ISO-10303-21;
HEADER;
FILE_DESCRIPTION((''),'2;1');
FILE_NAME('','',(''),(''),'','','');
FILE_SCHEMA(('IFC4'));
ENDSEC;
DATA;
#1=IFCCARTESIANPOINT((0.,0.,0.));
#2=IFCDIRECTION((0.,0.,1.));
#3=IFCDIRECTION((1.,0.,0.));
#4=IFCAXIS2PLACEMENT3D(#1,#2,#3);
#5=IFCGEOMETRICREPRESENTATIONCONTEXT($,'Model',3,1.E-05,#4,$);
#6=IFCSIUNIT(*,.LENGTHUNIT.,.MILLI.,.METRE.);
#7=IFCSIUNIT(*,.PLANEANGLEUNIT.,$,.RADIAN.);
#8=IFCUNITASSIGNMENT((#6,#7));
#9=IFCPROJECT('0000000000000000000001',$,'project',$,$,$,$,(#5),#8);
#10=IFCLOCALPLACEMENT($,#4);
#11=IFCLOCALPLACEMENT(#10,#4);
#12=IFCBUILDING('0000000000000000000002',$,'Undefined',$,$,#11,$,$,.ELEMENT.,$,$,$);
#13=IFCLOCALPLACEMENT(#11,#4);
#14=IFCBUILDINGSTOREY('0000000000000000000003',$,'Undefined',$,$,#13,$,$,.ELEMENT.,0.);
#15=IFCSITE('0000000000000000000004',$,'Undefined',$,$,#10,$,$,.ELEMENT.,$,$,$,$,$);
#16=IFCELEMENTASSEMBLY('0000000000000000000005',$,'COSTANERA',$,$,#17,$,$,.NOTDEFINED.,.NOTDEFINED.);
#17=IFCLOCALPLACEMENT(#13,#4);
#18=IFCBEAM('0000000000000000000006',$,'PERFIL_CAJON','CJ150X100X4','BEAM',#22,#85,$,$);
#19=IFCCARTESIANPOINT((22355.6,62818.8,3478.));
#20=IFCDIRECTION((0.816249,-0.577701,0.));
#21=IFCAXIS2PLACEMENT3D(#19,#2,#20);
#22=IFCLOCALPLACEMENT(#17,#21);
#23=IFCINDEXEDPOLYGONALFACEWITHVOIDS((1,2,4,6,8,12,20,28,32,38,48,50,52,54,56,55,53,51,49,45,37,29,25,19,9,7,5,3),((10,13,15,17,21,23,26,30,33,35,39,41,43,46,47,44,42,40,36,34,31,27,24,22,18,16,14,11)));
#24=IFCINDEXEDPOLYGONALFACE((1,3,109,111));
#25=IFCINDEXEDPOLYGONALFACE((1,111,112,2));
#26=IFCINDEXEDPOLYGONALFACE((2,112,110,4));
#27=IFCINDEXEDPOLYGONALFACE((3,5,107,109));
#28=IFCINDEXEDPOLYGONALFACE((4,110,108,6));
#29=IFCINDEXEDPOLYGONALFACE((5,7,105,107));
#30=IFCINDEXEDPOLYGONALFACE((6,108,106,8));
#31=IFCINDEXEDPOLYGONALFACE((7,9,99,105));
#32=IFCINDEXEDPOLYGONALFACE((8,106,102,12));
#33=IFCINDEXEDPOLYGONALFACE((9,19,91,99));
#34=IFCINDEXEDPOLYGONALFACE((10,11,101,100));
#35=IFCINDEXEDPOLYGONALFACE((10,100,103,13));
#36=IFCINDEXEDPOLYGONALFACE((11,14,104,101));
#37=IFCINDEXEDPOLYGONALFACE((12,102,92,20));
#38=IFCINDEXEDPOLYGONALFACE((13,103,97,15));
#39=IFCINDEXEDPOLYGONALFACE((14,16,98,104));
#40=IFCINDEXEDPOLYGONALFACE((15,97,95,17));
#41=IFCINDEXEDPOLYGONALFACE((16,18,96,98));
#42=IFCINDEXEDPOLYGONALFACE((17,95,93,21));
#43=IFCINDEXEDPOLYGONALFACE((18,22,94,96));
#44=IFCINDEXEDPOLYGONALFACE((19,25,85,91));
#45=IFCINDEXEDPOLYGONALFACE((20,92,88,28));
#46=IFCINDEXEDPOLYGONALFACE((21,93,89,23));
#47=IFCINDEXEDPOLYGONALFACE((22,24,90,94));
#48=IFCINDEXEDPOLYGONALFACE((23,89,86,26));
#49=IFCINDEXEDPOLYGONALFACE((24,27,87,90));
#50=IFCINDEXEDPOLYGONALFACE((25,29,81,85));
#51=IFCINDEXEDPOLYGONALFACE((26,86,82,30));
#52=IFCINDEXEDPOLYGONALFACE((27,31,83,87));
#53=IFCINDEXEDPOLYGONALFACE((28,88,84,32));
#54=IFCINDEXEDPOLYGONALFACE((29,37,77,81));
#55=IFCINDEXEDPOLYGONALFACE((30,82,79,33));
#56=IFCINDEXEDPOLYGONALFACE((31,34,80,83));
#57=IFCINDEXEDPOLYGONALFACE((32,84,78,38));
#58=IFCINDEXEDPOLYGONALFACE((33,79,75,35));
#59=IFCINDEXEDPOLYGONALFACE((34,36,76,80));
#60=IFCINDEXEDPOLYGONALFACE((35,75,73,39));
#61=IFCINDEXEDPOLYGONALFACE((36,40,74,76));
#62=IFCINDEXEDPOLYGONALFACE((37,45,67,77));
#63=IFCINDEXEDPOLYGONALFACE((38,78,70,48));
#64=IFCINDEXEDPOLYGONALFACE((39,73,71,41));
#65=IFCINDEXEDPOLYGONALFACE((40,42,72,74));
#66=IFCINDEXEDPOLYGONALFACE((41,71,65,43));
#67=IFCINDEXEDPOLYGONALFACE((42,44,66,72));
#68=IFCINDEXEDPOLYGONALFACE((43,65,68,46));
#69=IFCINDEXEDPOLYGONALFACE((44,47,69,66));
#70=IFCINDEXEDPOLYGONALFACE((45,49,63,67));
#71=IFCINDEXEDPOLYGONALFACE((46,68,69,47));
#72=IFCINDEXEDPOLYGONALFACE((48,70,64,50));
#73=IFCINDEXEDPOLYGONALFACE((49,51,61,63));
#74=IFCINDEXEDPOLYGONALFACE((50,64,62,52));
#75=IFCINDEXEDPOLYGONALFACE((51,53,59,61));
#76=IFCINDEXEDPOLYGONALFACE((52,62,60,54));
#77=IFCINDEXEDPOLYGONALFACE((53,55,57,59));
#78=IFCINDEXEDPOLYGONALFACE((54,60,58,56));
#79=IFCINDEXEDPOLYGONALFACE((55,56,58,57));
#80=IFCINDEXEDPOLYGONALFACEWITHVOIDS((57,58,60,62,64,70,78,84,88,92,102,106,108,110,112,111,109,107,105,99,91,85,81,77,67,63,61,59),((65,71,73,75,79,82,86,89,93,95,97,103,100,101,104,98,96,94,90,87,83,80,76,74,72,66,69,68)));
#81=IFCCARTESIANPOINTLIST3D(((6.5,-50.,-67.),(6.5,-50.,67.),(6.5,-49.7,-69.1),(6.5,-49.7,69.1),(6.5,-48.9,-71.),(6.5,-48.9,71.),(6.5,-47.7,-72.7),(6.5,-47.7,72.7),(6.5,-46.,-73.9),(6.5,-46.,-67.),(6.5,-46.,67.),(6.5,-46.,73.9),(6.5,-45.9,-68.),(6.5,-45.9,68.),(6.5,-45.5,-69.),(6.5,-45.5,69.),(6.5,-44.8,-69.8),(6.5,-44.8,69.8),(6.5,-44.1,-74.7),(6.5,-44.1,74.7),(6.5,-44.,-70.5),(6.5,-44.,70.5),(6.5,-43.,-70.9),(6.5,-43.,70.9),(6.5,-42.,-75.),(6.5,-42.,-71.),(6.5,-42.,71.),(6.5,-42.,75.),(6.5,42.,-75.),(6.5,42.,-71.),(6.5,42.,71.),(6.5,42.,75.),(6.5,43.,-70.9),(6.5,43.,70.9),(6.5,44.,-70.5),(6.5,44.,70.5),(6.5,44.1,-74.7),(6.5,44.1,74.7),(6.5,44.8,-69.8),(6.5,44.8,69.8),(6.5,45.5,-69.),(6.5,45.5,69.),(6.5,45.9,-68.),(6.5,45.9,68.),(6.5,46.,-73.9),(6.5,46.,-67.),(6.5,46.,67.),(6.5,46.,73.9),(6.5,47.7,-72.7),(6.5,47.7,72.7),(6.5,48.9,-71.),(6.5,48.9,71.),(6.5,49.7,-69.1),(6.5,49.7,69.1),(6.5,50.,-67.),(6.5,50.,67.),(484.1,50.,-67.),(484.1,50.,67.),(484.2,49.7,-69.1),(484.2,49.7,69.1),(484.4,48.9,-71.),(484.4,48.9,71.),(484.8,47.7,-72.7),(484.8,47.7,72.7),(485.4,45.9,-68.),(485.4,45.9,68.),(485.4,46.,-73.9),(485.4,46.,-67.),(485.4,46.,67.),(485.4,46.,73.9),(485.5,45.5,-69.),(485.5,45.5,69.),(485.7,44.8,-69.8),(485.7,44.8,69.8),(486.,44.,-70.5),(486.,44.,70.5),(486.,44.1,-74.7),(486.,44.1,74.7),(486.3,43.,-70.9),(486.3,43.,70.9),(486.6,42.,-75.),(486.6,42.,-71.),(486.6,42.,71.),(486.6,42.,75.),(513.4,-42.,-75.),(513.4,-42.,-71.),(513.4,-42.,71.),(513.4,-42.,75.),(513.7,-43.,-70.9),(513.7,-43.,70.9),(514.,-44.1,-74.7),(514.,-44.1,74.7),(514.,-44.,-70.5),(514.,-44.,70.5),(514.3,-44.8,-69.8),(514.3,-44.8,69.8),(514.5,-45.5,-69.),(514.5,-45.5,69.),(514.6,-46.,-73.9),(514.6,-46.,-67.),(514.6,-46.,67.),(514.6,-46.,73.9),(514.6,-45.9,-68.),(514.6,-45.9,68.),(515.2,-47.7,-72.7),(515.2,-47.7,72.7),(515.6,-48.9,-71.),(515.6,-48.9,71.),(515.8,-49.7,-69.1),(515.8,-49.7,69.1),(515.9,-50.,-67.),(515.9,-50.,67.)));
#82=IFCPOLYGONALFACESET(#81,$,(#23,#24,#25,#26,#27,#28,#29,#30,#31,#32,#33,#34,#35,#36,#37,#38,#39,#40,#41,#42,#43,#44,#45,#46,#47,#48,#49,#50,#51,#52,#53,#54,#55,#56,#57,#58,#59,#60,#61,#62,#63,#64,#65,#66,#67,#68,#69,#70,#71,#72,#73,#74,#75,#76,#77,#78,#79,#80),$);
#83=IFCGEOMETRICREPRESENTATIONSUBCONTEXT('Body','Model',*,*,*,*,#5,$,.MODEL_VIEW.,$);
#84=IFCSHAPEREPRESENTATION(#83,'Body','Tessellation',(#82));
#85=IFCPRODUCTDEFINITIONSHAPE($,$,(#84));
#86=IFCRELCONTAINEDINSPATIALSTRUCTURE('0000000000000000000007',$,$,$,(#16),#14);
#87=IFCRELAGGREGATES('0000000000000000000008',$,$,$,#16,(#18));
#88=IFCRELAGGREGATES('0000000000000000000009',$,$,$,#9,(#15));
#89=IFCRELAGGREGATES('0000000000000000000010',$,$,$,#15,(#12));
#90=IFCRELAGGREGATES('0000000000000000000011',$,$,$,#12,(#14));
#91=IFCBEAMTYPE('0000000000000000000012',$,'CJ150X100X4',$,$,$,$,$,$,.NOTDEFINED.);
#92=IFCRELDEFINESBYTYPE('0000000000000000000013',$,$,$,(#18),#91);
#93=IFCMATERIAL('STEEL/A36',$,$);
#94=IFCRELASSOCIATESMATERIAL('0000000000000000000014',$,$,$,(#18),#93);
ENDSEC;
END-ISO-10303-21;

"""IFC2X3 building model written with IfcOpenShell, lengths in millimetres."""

from ifc_helpers import new_model, si_unit, frame, origin_with_axes, origin_2d_with_axis, place, context, subcontext, project, spatial, hollow_rectangle, extrude, clip, halfspace, material, type_object, element, aggregate, save


model = new_model("IFC2X3")

# Units and contexts
model_context = context("Model", 3, precision=1e-05, world=origin_with_axes())
body_context = subcontext(model_context, "Body", "Model", "MODEL_VIEW")
ifc_project = project(units=[si_unit("LENGTHUNIT", "METRE", prefix="MILLI"), si_unit("PLANEANGLEUNIT", "RADIAN")], contexts=[model_context])

# Site, building, storey
site_placement = place(None, origin_with_axes())
site = spatial("IfcSite", under=ifc_project, at=site_placement, Name="Undefined", CompositionType="ELEMENT")
building_placement = place(site_placement, origin_with_axes())
building = spatial("IfcBuilding", under=site, at=building_placement, Name="Undefined", CompositionType="ELEMENT")
storey_placement = place(building_placement, origin_with_axes())
storey = spatial("IfcBuildingStorey", under=building, at=storey_placement, Name="Undefined", CompositionType="ELEMENT", Elevation=0.0)

# Shared definitions
ifc_material_1 = material(Name="STEEL/A36")
beam_type_1 = type_object("IfcBeamType", Name="CJ150X100X4", PredefinedType="NOTDEFINED")

# Element assembly, beam
assembly_1_placement = place(storey_placement, origin_with_axes())
assembly_1 = element("IfcElementAssembly", 1, at=assembly_1_placement, inside=storey, Name="COSTANERA", AssemblyPlace="NOTDEFINED", PredefinedType="NOTDEFINED")
beam_1_placement = place(assembly_1_placement, frame((22355.6, 62818.8, 3478.0), z_axis=(0.0, 0.0, 1.0), x_axis=(0.816249, -0.577701, 0.0)))
beam_1 = element("IfcBeam", 2, at=beam_1_placement, type_object=beam_type_1, material=ifc_material_1, Name="PERFIL_CAJON", Description="CJ150X100X4", ObjectType="BEAM", context=body_context, shape_type="Clipping", body=[
    clip(clip(extrude(hollow_rectangle(XDim=100.0, YDim=150.0, WallThickness=4.0, InnerFilletRadius=4.0, OuterFilletRadius=8.0, at=origin_2d_with_axis()), frame((589.9, 0.0, 0.0), z_axis=(-1.0, 0.0, 0.0), x_axis=(0.0, -1.0, 0.0)), (0.0, 0.0, 1.0), 673.3), halfspace(frame((515.9, -50.0, 0.0), z_axis=(0.952956, 0.30311, 0.0), x_axis=(0.0, 0.0, 1.0)), False)), halfspace(frame((6.5, 0.0, -75.0), z_axis=(1.0, 0.0, 0.0), x_axis=(0.0, -1.0, 0.0)), True)),
])

aggregate(assembly_1, [beam_1])

save(model, "model.ifc")
